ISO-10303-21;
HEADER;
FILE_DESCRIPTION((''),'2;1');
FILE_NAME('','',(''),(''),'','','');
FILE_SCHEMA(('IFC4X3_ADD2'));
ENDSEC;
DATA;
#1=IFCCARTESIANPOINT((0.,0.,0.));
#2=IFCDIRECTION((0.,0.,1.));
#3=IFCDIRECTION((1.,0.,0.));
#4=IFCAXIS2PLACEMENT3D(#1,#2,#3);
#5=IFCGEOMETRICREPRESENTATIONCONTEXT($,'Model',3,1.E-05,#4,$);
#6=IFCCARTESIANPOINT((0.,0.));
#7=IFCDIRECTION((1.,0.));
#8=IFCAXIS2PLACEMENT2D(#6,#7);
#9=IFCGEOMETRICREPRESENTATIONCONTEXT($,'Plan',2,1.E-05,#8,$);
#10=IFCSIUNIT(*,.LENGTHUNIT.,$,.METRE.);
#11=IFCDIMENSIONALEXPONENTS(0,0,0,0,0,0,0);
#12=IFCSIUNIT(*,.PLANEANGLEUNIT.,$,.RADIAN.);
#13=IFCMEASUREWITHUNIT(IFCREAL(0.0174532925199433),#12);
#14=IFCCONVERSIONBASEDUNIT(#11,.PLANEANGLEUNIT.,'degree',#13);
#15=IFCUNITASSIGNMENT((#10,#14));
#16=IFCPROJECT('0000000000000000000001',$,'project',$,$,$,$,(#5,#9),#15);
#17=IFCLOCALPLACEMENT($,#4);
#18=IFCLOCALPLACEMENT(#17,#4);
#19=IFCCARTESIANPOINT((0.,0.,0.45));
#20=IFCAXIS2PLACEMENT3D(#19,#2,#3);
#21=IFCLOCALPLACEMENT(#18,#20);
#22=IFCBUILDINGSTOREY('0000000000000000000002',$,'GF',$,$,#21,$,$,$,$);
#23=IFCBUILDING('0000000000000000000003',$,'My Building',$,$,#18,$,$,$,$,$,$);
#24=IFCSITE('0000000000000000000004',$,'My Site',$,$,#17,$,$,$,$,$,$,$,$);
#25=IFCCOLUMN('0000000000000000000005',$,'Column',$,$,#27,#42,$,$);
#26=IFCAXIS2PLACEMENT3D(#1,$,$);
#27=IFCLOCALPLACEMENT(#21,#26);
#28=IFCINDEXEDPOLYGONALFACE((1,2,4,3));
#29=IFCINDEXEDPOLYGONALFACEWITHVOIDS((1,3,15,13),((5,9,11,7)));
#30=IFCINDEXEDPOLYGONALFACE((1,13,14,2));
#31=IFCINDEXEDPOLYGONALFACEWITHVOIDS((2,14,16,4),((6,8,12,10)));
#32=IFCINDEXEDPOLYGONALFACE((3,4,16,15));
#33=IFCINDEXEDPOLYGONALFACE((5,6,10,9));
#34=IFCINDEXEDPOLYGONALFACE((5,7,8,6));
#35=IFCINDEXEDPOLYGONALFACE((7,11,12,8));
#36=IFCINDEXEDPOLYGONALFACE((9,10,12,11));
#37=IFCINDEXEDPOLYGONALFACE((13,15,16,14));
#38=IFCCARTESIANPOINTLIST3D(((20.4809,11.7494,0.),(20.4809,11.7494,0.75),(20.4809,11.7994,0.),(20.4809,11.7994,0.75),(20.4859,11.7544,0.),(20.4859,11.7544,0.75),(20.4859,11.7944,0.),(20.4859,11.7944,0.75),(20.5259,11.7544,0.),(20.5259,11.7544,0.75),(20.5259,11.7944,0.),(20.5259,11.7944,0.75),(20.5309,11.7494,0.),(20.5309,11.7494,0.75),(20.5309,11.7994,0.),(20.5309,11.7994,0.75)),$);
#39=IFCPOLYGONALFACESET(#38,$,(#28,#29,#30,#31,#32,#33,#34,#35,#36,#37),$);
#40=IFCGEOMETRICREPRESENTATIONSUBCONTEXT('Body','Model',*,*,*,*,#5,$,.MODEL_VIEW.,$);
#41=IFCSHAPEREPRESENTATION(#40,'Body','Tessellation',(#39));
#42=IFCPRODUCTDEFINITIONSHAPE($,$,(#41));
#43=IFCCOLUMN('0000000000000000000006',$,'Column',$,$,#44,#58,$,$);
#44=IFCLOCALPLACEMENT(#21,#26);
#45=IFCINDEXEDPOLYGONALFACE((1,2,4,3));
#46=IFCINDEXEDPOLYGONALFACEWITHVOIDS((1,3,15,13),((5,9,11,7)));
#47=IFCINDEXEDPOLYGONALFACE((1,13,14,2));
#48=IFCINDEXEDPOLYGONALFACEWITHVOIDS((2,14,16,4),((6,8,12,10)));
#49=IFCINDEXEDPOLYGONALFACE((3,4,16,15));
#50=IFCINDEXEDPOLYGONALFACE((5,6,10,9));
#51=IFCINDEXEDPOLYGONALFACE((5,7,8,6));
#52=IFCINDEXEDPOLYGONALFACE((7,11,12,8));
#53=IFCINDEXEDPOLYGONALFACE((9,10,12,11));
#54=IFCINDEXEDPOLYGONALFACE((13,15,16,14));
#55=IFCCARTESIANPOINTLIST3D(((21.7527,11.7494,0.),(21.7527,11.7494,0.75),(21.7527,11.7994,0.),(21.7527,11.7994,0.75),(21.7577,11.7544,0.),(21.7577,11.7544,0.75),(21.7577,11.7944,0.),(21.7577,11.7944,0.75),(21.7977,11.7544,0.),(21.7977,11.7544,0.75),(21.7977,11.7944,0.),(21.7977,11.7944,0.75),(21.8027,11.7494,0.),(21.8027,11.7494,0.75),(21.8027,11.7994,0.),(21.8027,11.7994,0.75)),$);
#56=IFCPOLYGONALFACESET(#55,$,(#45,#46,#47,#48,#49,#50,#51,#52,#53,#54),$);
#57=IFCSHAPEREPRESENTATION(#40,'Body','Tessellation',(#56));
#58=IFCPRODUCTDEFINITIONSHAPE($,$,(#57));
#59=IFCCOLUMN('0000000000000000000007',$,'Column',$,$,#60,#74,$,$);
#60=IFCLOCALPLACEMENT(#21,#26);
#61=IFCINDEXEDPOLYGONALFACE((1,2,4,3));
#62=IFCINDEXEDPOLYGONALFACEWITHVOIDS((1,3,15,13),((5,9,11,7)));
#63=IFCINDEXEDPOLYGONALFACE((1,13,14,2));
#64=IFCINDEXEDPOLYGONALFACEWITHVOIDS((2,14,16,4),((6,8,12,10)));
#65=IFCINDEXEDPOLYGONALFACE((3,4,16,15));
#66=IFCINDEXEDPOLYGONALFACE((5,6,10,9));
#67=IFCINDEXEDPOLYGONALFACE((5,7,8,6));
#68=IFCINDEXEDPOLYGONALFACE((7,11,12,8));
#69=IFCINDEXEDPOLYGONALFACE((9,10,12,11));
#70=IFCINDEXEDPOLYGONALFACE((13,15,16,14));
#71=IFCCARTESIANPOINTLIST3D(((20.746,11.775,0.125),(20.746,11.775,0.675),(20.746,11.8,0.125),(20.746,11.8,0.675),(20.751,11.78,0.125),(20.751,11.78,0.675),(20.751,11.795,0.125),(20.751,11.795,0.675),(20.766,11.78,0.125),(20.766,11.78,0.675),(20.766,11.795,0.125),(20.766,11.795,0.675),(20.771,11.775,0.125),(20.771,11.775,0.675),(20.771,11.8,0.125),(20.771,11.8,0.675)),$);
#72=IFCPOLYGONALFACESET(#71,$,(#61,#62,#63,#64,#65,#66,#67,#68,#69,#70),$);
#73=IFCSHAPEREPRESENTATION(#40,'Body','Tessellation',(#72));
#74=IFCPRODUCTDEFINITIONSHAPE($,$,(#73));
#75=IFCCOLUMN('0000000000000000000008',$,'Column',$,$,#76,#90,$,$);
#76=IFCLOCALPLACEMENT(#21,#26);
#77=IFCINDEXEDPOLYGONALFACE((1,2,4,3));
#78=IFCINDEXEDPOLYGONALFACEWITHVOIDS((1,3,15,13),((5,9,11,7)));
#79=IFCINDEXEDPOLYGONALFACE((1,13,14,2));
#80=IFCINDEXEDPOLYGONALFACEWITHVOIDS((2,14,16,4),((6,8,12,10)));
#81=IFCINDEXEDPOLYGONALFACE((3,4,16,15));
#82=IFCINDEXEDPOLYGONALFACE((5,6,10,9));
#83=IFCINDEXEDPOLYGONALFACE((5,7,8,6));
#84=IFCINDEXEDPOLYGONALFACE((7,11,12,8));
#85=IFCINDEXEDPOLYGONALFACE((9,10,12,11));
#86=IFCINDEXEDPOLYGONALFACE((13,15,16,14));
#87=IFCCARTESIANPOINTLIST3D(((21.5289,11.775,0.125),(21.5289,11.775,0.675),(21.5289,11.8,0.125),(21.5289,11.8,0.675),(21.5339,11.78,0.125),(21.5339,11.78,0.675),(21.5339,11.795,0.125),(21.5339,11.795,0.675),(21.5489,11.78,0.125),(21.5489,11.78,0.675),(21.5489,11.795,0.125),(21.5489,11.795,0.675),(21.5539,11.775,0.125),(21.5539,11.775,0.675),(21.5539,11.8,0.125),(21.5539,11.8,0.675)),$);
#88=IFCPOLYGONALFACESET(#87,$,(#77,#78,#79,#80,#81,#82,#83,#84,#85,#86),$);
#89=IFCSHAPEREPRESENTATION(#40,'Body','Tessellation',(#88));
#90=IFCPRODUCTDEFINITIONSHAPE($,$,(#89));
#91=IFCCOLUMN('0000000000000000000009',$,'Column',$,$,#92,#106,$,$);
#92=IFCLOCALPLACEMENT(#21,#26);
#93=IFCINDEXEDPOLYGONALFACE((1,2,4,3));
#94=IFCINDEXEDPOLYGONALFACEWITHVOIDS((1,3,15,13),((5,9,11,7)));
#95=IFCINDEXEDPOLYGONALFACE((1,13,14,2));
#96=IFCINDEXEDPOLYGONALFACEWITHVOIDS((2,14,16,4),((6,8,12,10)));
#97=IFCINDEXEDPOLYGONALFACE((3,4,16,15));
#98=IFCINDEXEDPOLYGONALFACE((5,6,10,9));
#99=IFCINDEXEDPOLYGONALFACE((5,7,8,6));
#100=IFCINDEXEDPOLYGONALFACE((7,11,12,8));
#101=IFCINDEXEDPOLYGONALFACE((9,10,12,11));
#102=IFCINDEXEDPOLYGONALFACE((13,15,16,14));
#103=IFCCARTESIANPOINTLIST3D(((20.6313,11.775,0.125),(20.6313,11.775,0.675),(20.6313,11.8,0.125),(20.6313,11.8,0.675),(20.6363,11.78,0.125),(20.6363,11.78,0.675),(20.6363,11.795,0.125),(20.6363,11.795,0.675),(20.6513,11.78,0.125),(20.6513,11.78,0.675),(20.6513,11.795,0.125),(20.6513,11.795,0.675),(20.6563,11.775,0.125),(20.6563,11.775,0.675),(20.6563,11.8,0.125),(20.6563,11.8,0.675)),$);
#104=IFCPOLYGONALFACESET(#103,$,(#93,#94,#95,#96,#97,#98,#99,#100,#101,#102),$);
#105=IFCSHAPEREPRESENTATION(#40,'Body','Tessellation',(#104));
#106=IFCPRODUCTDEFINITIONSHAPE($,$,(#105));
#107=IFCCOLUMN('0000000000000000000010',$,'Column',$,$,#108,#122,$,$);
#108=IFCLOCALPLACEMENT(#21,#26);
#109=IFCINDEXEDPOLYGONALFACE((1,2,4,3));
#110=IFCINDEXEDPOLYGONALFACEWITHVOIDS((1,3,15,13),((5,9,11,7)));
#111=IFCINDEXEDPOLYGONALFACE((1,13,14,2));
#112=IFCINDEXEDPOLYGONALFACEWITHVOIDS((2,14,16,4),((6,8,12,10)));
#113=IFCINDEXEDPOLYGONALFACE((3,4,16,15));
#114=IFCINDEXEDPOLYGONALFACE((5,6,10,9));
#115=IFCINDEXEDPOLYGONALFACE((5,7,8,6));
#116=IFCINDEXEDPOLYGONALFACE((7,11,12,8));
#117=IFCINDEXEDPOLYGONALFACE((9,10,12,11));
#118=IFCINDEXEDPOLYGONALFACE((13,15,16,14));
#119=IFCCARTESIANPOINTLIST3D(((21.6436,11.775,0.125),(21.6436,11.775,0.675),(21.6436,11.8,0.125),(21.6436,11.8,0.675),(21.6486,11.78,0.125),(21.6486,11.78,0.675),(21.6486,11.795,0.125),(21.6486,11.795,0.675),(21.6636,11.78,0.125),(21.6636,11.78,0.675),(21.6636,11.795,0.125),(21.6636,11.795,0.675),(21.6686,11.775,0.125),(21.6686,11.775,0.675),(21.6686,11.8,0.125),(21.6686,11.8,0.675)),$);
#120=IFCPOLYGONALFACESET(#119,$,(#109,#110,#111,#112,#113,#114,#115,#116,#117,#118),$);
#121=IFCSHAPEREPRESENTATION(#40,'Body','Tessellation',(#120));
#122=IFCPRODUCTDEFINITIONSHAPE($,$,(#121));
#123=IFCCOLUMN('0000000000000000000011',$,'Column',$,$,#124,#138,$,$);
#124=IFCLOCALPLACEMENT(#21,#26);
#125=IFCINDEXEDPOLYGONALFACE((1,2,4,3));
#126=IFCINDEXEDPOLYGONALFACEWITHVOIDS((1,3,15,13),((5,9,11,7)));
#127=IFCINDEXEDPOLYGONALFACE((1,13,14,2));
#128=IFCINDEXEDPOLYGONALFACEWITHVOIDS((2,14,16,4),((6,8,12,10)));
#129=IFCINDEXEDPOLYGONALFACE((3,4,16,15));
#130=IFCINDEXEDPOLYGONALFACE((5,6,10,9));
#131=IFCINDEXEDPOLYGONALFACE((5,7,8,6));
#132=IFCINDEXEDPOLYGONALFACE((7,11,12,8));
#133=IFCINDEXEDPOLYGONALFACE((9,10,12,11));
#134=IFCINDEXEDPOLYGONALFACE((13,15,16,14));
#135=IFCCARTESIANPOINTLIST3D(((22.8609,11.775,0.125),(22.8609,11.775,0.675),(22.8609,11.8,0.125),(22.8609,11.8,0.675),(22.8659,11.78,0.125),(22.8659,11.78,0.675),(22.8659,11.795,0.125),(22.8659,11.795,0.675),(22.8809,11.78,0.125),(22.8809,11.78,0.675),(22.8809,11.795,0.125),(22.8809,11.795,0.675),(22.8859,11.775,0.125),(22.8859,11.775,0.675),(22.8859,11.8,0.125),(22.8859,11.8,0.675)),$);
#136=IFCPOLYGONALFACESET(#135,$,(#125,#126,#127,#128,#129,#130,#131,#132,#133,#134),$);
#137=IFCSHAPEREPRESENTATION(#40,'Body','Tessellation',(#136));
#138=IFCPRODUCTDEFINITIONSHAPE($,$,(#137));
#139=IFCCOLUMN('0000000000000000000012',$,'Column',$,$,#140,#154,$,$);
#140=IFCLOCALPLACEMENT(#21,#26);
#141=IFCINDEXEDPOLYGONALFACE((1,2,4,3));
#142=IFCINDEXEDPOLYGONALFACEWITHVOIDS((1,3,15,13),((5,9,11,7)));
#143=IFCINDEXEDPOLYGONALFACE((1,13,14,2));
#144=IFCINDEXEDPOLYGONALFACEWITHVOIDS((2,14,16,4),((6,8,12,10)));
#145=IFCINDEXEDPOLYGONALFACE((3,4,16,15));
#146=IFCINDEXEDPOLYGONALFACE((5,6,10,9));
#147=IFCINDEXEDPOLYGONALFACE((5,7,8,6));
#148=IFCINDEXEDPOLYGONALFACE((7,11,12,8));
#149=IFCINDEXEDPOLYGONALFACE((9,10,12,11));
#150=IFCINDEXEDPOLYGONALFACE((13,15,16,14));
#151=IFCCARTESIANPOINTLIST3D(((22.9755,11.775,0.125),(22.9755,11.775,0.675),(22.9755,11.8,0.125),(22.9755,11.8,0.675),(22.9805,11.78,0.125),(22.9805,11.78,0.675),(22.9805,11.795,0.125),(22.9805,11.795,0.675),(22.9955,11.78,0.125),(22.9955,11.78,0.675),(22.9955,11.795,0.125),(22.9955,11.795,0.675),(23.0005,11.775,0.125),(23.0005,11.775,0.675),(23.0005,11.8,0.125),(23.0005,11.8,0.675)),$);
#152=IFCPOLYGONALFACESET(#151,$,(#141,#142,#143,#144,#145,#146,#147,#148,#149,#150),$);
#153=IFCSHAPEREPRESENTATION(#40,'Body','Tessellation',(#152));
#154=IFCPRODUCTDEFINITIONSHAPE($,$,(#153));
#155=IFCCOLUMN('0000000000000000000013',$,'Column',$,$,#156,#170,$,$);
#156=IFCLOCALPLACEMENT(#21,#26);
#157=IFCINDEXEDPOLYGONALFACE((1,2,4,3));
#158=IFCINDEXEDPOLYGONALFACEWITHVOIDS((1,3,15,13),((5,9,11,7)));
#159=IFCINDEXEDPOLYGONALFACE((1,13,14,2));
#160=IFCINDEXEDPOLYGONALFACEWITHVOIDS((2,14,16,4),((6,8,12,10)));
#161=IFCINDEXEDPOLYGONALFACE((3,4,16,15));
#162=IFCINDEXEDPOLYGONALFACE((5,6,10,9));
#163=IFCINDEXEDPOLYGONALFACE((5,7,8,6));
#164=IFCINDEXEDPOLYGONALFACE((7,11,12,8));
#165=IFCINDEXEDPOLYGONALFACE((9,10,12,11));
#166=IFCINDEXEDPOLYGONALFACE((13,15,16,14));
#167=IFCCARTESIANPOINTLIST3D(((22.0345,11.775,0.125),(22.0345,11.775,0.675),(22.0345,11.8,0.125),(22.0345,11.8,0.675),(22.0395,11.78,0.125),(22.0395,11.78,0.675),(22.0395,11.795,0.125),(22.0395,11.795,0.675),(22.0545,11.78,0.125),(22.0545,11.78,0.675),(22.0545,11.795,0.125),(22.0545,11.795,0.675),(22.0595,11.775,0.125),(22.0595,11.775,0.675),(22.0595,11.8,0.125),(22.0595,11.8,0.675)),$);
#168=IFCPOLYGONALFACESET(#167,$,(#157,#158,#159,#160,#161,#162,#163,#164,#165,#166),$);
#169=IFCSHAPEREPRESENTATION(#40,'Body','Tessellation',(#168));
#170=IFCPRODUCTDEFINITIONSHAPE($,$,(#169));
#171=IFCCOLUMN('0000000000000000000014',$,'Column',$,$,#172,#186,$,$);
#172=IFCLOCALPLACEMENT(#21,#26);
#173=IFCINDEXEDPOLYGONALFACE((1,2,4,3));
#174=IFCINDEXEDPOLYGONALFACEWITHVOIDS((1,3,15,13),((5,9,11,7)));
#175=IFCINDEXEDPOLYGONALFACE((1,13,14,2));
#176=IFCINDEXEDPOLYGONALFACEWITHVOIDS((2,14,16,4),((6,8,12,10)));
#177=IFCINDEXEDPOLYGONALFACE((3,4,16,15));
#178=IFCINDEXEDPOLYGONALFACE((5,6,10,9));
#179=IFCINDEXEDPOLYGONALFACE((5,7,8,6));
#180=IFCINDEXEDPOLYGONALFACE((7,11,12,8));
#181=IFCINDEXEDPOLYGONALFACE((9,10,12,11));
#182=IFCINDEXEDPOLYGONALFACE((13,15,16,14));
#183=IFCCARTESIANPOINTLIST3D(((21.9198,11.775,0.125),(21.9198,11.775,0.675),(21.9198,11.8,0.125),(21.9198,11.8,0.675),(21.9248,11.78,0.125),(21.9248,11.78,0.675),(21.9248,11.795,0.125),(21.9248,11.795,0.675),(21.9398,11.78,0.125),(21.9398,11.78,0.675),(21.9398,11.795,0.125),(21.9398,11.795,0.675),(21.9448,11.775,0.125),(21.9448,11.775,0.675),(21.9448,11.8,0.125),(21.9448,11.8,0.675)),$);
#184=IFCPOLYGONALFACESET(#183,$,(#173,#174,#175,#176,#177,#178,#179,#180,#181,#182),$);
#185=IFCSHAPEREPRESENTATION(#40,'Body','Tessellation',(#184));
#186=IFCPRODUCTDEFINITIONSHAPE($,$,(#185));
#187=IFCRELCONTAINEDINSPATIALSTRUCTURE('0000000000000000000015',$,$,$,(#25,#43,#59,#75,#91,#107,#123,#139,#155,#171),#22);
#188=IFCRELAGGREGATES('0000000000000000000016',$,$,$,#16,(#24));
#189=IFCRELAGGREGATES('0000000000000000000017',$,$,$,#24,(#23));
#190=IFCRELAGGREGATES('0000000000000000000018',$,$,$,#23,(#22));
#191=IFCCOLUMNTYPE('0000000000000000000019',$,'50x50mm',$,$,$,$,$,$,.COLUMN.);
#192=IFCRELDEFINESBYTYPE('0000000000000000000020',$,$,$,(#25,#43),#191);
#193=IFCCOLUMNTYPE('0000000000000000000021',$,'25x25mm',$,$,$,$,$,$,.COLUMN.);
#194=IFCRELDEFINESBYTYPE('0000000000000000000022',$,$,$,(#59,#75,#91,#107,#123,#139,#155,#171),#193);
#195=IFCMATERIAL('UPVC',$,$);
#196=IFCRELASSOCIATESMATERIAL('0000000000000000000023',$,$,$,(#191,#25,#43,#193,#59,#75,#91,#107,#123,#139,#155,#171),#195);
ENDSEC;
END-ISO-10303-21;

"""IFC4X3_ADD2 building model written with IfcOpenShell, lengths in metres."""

from ifc_helpers import new_model, entity, si_unit, converted_unit, frame, origin_with_axes, origin_2d_with_axis, place, context, subcontext, project, spatial, hollow_rectangle, extrude, material, material_profile, profile_set, profile_usage, type_object, element, save


model = new_model("IFC4X3_ADD2")

# Units and contexts
model_context = context("Model", 3, precision=1e-05, world=origin_with_axes())
plan_context = context("Plan", 2, precision=1e-05, world=origin_2d_with_axis())
body_context_1 = subcontext(model_context, "Body", "Model", "MODEL_VIEW")
ifc_project = project(units=[si_unit("LENGTHUNIT", "METRE"), converted_unit("PLANEANGLEUNIT", "degree", entity("IfcReal", 0.0174532925199433), si_unit("PLANEANGLEUNIT", "RADIAN"), dimensions=[0, 0, 0, 0, 0, 0, 0])], contexts=[model_context, plan_context])

# Site, building, storey
site_placement = place(None, origin_with_axes())
site = spatial("IfcSite", under=ifc_project, at=site_placement, Name="My Site")
building_placement = place(site_placement, origin_with_axes())
building = spatial("IfcBuilding", under=site, at=building_placement, Name="My Building")
storey_placement = place(building_placement, frame((0.0, 0.0, 0.45), z_axis=(0.0, 0.0, 1.0), x_axis=(1.0, 0.0, 0.0)))
storey = spatial("IfcBuildingStorey", under=building, at=storey_placement, Name="GF")

# Columns
ifc_material_1 = material(Name="UPVC")
ifc_material_profile_1 = material_profile(ifc_material_1, hollow_rectangle(XDim=0.05, YDim=0.05, WallThickness=0.005))
ifc_profile_set_1 = profile_set([ifc_material_profile_1])
ifc_profile_usage_1 = profile_usage(ifc_profile_set_1)
column_type_1 = type_object("IfcColumnType", Name="50x50mm", PredefinedType="COLUMN", material=ifc_profile_set_1)
column_1_placement = place(storey_placement, frame((20.5059, 11.7744, 0.0), z_axis=(0.0, 0.0, 1.0), x_axis=(1.0, 0.0, 0.0)))
element("IfcColumn", 1, at=column_1_placement, inside=storey, type_object=column_type_1, material=ifc_profile_usage_1, Name="Column", context=body_context_1, shape_type="SweptSolid", body=[
    extrude(hollow_rectangle(XDim=0.05, YDim=0.05, WallThickness=0.005), origin_with_axes(), (0.0, 0.0, 1.0), 0.75),
])
ifc_profile_usage_2 = profile_usage(ifc_profile_set_1)
column_2_placement = place(storey_placement, frame((21.7777, 11.7744, 0.0), z_axis=(0.0, 0.0, 1.0), x_axis=(1.0, 0.0, 0.0)))
element("IfcColumn", 2, at=column_2_placement, inside=storey, type_object=column_type_1, material=ifc_profile_usage_2, Name="Column", context=body_context_1, shape_type="SweptSolid", body=[
    extrude(hollow_rectangle(XDim=0.05, YDim=0.05, WallThickness=0.005), origin_with_axes(), (0.0, 0.0, 1.0), 0.75),
])
ifc_material_profile_2 = material_profile(ifc_material_1, hollow_rectangle(XDim=0.025, YDim=0.025, WallThickness=0.005))
ifc_profile_set_2 = profile_set([ifc_material_profile_2])
ifc_profile_usage_3 = profile_usage(ifc_profile_set_2, cardinal=5)
column_type_2 = type_object("IfcColumnType", Name="25x25mm", PredefinedType="COLUMN", material=ifc_profile_set_2)
column_3_placement = place(storey_placement, frame((20.7585, 11.7875, 0.125), z_axis=(0.0, 0.0, 1.0), x_axis=(1.0, 0.0, 0.0)))
element("IfcColumn", 3, at=column_3_placement, inside=storey, type_object=column_type_2, material=ifc_profile_usage_3, Name="Column", context=body_context_1, shape_type="SweptSolid", body=[
    extrude(hollow_rectangle(XDim=0.025, YDim=0.025, WallThickness=0.005), origin_with_axes(), (0.0, 0.0, 1.0), 0.55),
])
ifc_profile_usage_4 = profile_usage(ifc_profile_set_2, cardinal=5)
column_4_placement = place(storey_placement, frame((21.5414, 11.7875, 0.125), z_axis=(0.0, 0.0, 1.0), x_axis=(1.0, 0.0, 0.0)))
element("IfcColumn", 4, at=column_4_placement, inside=storey, type_object=column_type_2, material=ifc_profile_usage_4, Name="Column", context=body_context_1, shape_type="SweptSolid", body=[
    extrude(hollow_rectangle(XDim=0.025, YDim=0.025, WallThickness=0.005), origin_with_axes(), (0.0, 0.0, 1.0), 0.55),
])
ifc_profile_usage_5 = profile_usage(ifc_profile_set_2, cardinal=5)
column_5_placement = place(storey_placement, frame((20.6438, 11.7875, 0.125), z_axis=(0.0, 0.0, 1.0), x_axis=(1.0, 0.0, 0.0)))
element("IfcColumn", 5, at=column_5_placement, inside=storey, type_object=column_type_2, material=ifc_profile_usage_5, Name="Column", context=body_context_1, shape_type="SweptSolid", body=[
    extrude(hollow_rectangle(XDim=0.025, YDim=0.025, WallThickness=0.005), origin_with_axes(), (0.0, 0.0, 1.0), 0.55),
])
ifc_profile_usage_6 = profile_usage(ifc_profile_set_2, cardinal=5)
column_6_placement = place(storey_placement, frame((21.6561, 11.7875, 0.125), z_axis=(0.0, 0.0, 1.0), x_axis=(1.0, 0.0, 0.0)))
element("IfcColumn", 6, at=column_6_placement, inside=storey, type_object=column_type_2, material=ifc_profile_usage_6, Name="Column", context=body_context_1, shape_type="SweptSolid", body=[
    extrude(hollow_rectangle(XDim=0.025, YDim=0.025, WallThickness=0.005), origin_with_axes(), (0.0, 0.0, 1.0), 0.55),
])
ifc_profile_usage_7 = profile_usage(ifc_profile_set_2, cardinal=5)
column_7_placement = place(storey_placement, frame((22.8734, 11.7875, 0.125), z_axis=(0.0, 0.0, 1.0), x_axis=(1.0, 0.0, 0.0)))
element("IfcColumn", 7, at=column_7_placement, inside=storey, type_object=column_type_2, material=ifc_profile_usage_7, Name="Column", context=body_context_1, shape_type="SweptSolid", body=[
    extrude(hollow_rectangle(XDim=0.025, YDim=0.025, WallThickness=0.005), origin_with_axes(), (0.0, 0.0, 1.0), 0.55),
])
ifc_profile_usage_8 = profile_usage(ifc_profile_set_2, cardinal=5)
column_8_placement = place(storey_placement, frame((22.988, 11.7875, 0.125), z_axis=(0.0, 0.0, 1.0), x_axis=(1.0, 0.0, 0.0)))
element("IfcColumn", 8, at=column_8_placement, inside=storey, type_object=column_type_2, material=ifc_profile_usage_8, Name="Column", context=body_context_1, shape_type="SweptSolid", body=[
    extrude(hollow_rectangle(XDim=0.025, YDim=0.025, WallThickness=0.005), origin_with_axes(), (0.0, 0.0, 1.0), 0.55),
])
ifc_profile_usage_9 = profile_usage(ifc_profile_set_2, cardinal=5)
column_9_placement = place(storey_placement, frame((22.047, 11.7875, 0.125), z_axis=(0.0, 0.0, 1.0), x_axis=(1.0, 0.0, 0.0)))
element("IfcColumn", 9, at=column_9_placement, inside=storey, type_object=column_type_2, material=ifc_profile_usage_9, Name="Column", context=body_context_1, shape_type="SweptSolid", body=[
    extrude(hollow_rectangle(XDim=0.025, YDim=0.025, WallThickness=0.005), origin_with_axes(), (0.0, 0.0, 1.0), 0.55),
])
ifc_profile_usage_10 = profile_usage(ifc_profile_set_2, cardinal=5)
column_10_placement = place(storey_placement, frame((21.9323, 11.7875, 0.125), z_axis=(0.0, 0.0, 1.0), x_axis=(1.0, 0.0, 0.0)))
element("IfcColumn", 10, at=column_10_placement, inside=storey, type_object=column_type_2, material=ifc_profile_usage_10, Name="Column", context=body_context_1, shape_type="SweptSolid", body=[
    extrude(hollow_rectangle(XDim=0.025, YDim=0.025, WallThickness=0.005), origin_with_axes(), (0.0, 0.0, 1.0), 0.55),
])

save(model, "model.ifc")
